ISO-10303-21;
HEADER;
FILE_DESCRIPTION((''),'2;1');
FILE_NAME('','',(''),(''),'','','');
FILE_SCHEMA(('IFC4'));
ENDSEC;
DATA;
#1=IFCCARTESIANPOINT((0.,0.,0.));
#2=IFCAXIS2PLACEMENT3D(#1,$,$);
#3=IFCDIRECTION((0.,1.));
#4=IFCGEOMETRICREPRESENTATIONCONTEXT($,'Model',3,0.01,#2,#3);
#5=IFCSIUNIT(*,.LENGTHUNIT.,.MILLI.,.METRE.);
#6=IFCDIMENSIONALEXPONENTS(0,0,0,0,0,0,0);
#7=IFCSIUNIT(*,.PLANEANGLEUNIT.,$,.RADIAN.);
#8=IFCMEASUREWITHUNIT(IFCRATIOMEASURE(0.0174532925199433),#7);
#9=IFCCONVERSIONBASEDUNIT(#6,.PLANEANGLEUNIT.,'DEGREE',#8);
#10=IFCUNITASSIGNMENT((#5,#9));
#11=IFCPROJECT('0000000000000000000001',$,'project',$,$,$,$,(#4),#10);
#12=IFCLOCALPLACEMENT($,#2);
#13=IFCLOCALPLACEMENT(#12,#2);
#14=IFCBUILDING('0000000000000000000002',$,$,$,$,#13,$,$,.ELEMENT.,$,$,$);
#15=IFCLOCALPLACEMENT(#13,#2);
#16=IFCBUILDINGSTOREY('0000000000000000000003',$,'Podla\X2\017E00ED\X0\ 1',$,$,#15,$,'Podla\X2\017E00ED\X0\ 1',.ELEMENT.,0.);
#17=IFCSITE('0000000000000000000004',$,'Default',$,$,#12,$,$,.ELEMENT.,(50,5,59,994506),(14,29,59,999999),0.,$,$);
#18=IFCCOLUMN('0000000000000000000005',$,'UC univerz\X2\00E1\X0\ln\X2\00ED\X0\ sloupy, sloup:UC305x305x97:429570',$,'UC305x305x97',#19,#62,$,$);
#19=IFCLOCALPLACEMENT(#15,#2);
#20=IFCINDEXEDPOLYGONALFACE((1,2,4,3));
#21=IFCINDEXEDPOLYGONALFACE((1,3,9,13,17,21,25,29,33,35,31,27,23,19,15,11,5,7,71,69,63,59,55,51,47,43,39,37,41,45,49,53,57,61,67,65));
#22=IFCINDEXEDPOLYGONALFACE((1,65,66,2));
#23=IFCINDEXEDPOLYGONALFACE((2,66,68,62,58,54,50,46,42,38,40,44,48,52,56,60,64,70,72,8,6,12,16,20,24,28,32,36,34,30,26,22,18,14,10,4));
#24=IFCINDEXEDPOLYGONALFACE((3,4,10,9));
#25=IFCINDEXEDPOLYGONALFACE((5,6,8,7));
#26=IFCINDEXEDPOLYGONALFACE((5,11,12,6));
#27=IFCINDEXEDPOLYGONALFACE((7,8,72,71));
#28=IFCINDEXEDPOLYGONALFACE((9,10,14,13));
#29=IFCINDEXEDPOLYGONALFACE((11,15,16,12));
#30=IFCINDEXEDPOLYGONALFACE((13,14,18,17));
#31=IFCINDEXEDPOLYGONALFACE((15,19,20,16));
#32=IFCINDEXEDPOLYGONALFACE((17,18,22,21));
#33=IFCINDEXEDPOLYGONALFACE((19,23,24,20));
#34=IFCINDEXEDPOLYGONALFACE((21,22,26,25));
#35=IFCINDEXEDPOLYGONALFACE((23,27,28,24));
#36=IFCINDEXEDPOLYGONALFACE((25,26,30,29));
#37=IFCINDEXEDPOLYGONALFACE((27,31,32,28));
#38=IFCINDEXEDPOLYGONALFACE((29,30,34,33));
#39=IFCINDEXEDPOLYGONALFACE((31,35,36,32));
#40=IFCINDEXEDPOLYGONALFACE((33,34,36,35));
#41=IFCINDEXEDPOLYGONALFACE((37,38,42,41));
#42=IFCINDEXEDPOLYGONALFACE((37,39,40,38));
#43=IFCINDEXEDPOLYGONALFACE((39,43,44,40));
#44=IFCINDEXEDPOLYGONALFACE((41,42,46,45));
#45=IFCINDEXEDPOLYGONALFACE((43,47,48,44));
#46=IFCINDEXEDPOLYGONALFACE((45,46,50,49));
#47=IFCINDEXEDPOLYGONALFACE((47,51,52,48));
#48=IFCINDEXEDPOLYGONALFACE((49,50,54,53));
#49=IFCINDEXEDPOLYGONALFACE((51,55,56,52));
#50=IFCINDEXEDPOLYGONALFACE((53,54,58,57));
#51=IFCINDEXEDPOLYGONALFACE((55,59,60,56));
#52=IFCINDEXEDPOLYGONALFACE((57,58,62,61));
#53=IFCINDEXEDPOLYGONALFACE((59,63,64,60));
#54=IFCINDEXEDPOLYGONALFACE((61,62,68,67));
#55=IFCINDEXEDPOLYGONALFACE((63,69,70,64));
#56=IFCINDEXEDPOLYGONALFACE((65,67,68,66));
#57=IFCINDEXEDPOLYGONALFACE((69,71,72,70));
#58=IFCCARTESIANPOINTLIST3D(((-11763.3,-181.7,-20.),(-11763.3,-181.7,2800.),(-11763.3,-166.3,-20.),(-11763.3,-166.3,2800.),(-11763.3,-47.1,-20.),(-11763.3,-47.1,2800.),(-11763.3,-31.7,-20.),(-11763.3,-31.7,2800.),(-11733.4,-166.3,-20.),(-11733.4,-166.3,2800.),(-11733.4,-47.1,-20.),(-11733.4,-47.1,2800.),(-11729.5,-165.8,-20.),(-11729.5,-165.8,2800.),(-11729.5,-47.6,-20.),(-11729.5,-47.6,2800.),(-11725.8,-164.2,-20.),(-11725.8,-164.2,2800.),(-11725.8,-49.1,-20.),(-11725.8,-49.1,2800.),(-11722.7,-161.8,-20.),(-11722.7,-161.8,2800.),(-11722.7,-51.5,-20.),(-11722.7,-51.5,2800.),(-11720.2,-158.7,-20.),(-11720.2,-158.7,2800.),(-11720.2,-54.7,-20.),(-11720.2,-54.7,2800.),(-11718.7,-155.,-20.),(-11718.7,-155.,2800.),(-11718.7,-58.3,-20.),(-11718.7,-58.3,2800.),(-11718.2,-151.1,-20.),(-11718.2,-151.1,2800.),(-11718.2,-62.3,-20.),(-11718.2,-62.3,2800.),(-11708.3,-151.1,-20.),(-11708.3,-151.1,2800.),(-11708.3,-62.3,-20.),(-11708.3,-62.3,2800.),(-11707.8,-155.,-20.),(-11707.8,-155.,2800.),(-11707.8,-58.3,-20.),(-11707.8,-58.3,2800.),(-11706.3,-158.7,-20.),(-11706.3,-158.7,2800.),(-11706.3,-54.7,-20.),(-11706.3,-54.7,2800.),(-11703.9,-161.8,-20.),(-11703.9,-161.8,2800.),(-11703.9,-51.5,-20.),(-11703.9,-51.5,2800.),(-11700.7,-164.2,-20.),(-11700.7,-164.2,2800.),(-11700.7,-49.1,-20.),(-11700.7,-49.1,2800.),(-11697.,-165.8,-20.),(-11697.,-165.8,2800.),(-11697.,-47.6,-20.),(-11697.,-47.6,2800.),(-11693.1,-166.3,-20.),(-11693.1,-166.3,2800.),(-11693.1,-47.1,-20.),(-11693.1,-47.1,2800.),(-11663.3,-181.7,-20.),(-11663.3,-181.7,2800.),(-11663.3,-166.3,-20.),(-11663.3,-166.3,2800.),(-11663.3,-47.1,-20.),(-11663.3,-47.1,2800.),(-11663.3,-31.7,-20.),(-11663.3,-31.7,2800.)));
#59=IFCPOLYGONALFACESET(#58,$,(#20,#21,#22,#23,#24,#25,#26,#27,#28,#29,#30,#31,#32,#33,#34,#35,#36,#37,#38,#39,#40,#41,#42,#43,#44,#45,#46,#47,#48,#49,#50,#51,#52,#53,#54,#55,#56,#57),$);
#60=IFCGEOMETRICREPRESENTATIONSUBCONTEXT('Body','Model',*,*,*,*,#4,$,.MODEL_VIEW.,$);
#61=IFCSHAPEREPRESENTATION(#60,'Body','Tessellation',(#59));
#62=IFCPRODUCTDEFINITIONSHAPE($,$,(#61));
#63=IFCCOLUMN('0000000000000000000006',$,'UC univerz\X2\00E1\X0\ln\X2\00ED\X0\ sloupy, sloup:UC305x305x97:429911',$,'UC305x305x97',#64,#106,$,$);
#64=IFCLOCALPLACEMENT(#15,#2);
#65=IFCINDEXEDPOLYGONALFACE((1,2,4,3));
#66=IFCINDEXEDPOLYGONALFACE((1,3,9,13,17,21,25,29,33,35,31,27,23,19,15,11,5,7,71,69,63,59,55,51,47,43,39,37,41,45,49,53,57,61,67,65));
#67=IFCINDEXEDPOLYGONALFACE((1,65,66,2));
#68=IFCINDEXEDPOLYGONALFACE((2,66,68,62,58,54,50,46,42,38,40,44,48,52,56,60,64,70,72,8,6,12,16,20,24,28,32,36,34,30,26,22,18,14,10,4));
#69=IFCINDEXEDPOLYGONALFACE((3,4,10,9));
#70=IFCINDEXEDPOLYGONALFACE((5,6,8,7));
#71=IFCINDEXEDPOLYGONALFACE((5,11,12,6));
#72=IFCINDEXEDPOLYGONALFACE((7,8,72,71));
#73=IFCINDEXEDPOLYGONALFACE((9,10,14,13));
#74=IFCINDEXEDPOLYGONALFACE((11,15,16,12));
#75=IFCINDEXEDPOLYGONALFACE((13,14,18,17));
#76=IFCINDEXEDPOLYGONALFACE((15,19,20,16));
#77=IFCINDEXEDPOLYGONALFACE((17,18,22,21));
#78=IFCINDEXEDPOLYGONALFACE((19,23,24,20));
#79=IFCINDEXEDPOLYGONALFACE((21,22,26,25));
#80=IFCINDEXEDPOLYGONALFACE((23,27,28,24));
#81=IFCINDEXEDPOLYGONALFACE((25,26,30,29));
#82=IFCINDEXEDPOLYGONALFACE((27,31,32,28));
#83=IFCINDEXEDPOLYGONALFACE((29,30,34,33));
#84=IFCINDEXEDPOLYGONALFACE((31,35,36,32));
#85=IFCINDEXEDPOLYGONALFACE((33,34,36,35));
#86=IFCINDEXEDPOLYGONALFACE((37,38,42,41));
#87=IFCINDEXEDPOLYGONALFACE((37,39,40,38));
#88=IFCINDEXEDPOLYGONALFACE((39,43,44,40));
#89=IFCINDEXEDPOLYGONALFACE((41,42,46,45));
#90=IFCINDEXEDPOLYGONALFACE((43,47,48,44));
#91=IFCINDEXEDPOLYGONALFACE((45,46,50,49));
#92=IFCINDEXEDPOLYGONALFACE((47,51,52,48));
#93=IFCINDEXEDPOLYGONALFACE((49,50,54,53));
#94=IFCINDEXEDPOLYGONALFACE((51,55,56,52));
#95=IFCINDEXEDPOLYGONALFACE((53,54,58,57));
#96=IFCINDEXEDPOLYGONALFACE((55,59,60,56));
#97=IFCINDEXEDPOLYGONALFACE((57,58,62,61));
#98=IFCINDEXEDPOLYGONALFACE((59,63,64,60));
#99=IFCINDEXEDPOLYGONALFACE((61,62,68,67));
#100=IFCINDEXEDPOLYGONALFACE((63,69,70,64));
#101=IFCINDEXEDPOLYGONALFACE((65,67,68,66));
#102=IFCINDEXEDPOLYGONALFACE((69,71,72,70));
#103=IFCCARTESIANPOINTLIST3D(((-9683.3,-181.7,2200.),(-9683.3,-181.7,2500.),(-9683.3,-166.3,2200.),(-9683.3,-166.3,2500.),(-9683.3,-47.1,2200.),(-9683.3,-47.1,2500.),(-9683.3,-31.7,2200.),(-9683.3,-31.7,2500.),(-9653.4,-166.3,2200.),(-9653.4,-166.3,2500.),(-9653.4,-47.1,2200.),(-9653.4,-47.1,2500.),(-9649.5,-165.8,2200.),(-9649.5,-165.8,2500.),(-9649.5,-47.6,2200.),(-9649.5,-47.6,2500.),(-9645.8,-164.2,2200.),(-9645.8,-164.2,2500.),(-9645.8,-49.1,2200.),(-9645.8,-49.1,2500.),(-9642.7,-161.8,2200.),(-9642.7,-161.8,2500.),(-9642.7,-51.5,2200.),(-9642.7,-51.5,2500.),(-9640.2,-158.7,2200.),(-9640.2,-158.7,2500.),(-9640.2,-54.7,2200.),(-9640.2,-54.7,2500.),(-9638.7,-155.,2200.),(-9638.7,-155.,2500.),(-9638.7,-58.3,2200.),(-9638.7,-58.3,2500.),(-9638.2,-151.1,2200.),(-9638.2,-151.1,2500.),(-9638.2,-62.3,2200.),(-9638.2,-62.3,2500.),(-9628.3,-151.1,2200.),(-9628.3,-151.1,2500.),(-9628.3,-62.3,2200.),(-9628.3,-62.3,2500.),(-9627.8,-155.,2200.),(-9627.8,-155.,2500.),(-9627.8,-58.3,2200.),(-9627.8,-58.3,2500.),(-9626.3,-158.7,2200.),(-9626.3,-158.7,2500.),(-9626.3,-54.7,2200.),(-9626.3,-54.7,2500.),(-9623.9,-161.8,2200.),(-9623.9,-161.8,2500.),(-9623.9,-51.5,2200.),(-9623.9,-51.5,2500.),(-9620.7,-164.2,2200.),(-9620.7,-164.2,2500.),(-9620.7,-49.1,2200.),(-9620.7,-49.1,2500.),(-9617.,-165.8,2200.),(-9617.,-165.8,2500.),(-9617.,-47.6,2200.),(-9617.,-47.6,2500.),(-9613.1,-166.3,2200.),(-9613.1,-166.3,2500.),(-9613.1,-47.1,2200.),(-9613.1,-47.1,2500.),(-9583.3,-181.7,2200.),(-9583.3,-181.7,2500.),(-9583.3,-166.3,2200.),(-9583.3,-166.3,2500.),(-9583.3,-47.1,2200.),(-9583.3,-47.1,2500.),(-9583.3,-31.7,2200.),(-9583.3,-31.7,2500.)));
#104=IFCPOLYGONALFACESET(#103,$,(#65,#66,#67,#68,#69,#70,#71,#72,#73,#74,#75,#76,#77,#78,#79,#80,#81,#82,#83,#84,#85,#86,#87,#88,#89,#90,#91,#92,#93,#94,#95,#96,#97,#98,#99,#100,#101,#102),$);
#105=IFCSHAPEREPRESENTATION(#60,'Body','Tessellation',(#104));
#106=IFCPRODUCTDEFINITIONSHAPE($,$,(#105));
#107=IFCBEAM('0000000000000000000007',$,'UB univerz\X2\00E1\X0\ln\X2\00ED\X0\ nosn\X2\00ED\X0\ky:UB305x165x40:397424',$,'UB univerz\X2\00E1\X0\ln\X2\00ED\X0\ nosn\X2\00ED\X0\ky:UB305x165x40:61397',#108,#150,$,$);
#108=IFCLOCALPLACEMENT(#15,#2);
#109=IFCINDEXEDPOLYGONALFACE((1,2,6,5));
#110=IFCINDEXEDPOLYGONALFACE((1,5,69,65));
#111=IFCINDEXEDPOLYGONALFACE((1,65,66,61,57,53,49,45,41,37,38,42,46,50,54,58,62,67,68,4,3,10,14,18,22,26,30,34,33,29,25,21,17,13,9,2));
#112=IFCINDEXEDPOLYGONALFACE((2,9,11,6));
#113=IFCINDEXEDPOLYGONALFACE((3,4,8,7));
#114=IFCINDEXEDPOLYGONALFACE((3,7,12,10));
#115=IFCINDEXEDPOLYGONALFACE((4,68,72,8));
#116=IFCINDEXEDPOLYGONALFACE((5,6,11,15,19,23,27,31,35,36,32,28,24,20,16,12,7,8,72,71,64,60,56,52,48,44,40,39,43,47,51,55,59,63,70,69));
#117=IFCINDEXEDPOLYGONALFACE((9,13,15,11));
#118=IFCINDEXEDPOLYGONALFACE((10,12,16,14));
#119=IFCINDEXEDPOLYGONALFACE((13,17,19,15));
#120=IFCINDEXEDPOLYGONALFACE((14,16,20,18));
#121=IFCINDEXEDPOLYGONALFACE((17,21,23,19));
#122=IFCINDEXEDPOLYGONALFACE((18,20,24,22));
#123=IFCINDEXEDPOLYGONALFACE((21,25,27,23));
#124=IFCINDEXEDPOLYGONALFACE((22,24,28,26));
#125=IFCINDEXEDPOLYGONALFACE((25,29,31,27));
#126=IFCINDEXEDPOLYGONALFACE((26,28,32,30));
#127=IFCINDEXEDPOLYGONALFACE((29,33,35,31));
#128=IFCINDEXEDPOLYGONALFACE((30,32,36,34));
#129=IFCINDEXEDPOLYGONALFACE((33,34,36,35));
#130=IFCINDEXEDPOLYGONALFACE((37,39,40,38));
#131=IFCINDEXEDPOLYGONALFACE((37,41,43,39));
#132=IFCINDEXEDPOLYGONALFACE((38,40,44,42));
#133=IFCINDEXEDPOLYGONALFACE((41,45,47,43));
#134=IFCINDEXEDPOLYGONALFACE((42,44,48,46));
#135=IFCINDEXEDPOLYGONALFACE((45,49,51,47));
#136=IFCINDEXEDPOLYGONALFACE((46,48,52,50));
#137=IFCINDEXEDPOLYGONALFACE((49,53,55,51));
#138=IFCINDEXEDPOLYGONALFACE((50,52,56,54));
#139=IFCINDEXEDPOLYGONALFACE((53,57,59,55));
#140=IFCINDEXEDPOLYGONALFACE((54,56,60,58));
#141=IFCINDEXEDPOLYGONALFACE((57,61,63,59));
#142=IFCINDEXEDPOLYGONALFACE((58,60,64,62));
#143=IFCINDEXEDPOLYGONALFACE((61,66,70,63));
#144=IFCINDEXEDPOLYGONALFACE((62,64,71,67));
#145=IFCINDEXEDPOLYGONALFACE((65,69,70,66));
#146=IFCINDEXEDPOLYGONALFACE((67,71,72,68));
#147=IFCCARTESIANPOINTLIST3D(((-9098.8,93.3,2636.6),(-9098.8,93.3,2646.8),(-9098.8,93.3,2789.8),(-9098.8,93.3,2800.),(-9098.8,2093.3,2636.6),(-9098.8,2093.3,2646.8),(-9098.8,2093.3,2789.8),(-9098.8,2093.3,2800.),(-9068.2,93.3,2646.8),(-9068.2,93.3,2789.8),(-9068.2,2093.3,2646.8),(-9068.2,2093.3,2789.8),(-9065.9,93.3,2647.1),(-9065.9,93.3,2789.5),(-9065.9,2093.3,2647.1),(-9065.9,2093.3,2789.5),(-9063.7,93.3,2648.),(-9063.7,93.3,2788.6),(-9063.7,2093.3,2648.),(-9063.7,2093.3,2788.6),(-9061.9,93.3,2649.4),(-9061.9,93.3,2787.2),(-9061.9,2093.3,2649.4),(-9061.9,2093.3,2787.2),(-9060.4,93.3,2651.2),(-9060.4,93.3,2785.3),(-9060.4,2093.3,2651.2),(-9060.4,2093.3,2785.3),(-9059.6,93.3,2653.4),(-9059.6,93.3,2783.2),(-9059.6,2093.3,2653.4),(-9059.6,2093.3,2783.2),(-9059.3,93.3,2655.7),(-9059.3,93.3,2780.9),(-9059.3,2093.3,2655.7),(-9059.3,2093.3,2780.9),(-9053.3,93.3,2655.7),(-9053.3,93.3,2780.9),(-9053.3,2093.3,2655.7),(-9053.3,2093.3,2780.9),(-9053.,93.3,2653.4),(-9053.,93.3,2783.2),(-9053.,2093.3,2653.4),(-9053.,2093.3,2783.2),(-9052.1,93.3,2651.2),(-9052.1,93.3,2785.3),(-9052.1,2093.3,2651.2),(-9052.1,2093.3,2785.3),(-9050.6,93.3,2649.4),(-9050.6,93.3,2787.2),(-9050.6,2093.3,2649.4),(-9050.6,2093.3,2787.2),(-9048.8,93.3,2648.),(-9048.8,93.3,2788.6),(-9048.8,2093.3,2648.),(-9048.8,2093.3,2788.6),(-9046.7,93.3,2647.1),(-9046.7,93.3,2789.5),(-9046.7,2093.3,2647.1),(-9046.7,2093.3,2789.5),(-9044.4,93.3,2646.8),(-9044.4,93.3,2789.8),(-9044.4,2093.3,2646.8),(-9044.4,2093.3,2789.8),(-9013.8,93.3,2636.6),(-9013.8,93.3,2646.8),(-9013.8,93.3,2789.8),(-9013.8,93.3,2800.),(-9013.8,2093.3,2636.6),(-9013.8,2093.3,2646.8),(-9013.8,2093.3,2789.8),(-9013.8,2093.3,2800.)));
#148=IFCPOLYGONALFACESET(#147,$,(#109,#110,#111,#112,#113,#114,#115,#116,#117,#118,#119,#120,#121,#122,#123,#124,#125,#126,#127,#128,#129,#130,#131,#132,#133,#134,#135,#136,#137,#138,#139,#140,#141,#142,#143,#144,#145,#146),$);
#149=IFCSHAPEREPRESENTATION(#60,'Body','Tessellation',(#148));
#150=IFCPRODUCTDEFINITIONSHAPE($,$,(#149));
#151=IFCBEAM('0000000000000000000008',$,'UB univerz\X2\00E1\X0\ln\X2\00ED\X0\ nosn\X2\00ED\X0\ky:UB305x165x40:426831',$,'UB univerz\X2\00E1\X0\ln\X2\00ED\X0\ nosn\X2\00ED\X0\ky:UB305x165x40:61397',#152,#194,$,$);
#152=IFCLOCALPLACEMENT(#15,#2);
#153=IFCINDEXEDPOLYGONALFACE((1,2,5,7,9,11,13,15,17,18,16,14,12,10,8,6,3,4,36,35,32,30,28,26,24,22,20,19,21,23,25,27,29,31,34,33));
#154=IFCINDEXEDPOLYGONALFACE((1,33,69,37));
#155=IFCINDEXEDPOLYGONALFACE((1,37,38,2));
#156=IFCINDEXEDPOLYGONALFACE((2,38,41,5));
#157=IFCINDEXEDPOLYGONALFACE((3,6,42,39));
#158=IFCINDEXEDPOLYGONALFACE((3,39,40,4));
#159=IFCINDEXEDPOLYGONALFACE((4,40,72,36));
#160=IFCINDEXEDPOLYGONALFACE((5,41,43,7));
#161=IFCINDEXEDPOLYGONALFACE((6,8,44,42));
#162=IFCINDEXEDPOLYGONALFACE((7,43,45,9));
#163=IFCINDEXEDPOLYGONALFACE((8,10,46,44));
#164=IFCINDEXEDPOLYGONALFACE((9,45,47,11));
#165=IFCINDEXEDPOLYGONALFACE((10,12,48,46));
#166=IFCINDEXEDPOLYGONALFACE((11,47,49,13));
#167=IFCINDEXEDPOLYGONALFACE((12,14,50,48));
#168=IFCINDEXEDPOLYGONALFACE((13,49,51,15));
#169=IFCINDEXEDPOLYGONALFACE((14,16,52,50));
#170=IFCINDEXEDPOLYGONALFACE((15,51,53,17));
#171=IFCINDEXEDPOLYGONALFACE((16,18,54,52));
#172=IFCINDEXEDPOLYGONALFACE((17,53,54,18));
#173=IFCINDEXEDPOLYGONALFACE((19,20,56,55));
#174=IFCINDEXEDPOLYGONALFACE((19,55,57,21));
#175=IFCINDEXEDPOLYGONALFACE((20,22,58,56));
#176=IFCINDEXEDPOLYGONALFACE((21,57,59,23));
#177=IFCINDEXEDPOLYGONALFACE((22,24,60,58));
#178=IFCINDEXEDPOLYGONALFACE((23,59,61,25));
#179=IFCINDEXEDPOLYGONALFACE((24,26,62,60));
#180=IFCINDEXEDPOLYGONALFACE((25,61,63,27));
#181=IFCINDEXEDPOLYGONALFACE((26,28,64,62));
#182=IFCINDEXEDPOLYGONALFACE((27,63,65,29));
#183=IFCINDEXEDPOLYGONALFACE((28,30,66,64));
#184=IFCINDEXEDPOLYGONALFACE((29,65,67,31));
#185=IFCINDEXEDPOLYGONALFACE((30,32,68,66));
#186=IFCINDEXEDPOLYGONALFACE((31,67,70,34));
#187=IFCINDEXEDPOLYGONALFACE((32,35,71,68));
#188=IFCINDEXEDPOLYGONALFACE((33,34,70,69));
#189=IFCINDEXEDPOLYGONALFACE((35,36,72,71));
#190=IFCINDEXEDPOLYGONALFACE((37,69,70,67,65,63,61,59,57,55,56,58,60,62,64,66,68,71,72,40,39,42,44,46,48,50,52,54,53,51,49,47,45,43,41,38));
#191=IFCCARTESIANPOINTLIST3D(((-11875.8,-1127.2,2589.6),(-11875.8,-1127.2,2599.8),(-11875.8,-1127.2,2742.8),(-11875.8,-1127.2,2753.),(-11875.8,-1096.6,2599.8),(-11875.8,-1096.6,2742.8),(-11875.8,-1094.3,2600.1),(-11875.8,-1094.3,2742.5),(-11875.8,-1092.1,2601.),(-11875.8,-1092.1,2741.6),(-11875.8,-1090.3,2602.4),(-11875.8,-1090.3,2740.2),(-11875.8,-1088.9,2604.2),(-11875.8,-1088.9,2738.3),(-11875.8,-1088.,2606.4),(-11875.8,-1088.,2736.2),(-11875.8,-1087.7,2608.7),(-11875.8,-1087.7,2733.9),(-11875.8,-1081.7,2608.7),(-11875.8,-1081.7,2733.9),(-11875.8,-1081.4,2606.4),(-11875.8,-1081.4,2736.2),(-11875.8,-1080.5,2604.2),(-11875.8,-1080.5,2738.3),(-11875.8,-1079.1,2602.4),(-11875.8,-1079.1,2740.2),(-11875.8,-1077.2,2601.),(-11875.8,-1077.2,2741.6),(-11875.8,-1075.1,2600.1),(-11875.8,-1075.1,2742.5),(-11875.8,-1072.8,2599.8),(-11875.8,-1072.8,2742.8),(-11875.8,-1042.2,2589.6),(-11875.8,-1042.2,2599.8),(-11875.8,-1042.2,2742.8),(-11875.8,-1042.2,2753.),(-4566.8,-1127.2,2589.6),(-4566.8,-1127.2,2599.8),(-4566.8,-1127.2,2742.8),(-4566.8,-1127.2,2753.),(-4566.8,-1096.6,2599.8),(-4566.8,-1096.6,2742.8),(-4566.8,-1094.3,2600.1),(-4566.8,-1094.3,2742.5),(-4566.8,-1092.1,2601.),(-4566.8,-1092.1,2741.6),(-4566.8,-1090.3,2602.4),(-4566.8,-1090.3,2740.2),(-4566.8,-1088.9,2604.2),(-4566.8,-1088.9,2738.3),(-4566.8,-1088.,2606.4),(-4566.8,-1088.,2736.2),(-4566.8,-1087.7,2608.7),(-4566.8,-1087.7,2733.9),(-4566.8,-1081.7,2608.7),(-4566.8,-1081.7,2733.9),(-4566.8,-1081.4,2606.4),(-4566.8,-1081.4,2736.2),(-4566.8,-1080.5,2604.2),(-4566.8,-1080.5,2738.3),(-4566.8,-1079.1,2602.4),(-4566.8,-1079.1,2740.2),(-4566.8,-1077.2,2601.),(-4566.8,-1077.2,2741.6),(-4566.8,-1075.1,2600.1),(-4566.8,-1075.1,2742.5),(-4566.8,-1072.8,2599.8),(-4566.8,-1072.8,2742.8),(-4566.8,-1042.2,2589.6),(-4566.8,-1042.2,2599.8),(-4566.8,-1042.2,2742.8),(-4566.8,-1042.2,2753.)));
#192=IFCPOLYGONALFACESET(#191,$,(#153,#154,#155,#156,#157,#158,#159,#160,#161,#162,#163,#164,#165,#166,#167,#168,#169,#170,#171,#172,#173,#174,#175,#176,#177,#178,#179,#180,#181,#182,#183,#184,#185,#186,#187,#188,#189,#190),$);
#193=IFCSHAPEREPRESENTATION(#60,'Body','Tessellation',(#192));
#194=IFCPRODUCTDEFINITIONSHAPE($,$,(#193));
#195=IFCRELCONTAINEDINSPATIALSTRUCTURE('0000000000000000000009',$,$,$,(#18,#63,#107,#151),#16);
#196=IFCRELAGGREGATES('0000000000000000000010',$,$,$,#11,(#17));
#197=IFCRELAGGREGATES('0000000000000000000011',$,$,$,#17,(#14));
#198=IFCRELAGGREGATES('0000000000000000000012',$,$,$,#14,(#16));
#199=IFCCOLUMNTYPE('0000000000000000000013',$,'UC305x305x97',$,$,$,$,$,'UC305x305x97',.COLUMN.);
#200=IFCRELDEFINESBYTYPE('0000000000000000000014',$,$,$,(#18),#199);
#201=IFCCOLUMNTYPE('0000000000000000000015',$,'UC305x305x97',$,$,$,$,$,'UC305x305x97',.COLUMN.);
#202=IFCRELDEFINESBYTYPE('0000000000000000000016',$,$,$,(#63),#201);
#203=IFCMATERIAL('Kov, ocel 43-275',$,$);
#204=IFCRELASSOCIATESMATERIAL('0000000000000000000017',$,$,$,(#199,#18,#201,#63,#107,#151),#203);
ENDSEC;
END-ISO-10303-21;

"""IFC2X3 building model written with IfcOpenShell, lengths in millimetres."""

from ifc_helpers import new_model, entity, si_unit, converted_unit, direction, frame, frame_2d, origin, place, context, subcontext, project, spatial, i_section, extrude, source, transform, mapped, material, type_object, type_shapes, element, save


model = new_model("IFC2X3")

# Units and contexts
model_context = context("Model", 3, precision=0.01, world=origin(), true_north=direction((0.0, 1.0)))
body_context = subcontext(model_context, "Body", "Model", "MODEL_VIEW")
ifc_project = project(units=[si_unit("LENGTHUNIT", "METRE", prefix="MILLI"), converted_unit("PLANEANGLEUNIT", "DEGREE", entity("IfcRatioMeasure", 0.0174532925199433), si_unit("PLANEANGLEUNIT", "RADIAN"), dimensions=[0, 0, 0, 0, 0, 0, 0])], contexts=[model_context])

# Site, building, storey
site_placement = place(None, origin())
site = spatial("IfcSite", under=ifc_project, at=site_placement, Name="Default", CompositionType="ELEMENT", RefLatitude=(50, 5, 59, 994506), RefLongitude=(14, 29, 59, 999999), RefElevation=0.0)
building_placement = place(site_placement, origin())
building = spatial("IfcBuilding", under=site, at=building_placement, CompositionType="ELEMENT")
storey_placement = place(building_placement, origin())
storey = spatial("IfcBuildingStorey", under=building, at=storey_placement, Name="Podlaží 1", LongName="Podlaží 1", CompositionType="ELEMENT", Elevation=0.0)

# Columns
ifc_material = material(Name="Kov, ocel 43-275")
column_type_1 = type_object("IfcColumnType", Name="UC305x305x97", ElementType="UC305x305x97", PredefinedType="COLUMN", material=ifc_material)
shared_shape_1 = source(origin(), body_context, "Body", "SweptSolid", [
    extrude(i_section(OverallWidth=100.0, OverallDepth=150.0, WebThickness=9.9, FlangeThickness=15.4, FilletRadius=15.2, at=frame_2d((0.0, 0.0), x_axis=(0.0, 1.0))), frame((0.0, 0.0, -20.0), z_axis=(0.0, 0.0, 1.0), x_axis=(0.0, -1.0, 0.0)), (0.0, 0.0, 1.0), 2820.0),
])
type_shapes(column_type_1, [shared_shape_1])
column_1_placement = place(storey_placement, frame((-11713.3, -106.7, 0.0)))
element("IfcColumn", 1, at=column_1_placement, inside=storey, type_object=column_type_1, material=ifc_material, Name="UC univerzální sloupy, sloup:UC305x305x97:429570", ObjectType="UC305x305x97", context=body_context, shape_type="MappedRepresentation", body=[
    mapped(shared_shape_1, transform((0.0, 0.0, 0.0), scale=1.0)),
])
column_type_2 = type_object("IfcColumnType", Name="UC305x305x97", ElementType="UC305x305x97", PredefinedType="COLUMN", material=ifc_material)
shared_shape_2 = source(origin(), body_context, "Body", "SweptSolid", [
    extrude(i_section(OverallWidth=100.0, OverallDepth=150.0, WebThickness=9.9, FlangeThickness=15.4, FilletRadius=15.2, at=frame_2d((0.0, 0.0), x_axis=(0.0, 1.0))), frame((0.0, 0.0, 2200.0), z_axis=(0.0, 0.0, 1.0), x_axis=(0.0, -1.0, 0.0)), (0.0, 0.0, 1.0), 300.0),
])
type_shapes(column_type_2, [shared_shape_2])
column_2_placement = place(storey_placement, frame((-9633.3, -106.7, 0.0)))
element("IfcColumn", 2, at=column_2_placement, inside=storey, type_object=column_type_2, material=ifc_material, Name="UC univerzální sloupy, sloup:UC305x305x97:429911", ObjectType="UC305x305x97", context=body_context, shape_type="MappedRepresentation", body=[
    mapped(shared_shape_2, transform((0.0, 0.0, 0.0), scale=1.0)),
])

# Beams
beam_1_placement = place(storey_placement, frame((-9056.3, 2093.3, 0.0), z_axis=(0.0, 0.0, 1.0), x_axis=(0.0, -1.0, 0.0)))
element("IfcBeam", 3, at=beam_1_placement, inside=storey, material=ifc_material, Name="UB univerzální nosníky:UB305x165x40:397424", ObjectType="UB univerzální nosníky:UB305x165x40:61397", context=body_context, shape_type="SweptSolid", body=[
    extrude(i_section(OverallWidth=85.0, OverallDepth=163.4, WebThickness=6.0, FlangeThickness=10.2, FilletRadius=8.9, at=frame_2d((0.0, 0.0), x_axis=(0.0, 1.0))), frame((0.0, 0.0, 2718.3), z_axis=(1.0, 0.0, 0.0), x_axis=(0.0, 0.0, -1.0)), (0.0, 0.0, 1.0), 2000.0),
])
beam_2_placement = place(storey_placement, frame((-4566.8, -1084.7, 0.0), z_axis=(0.0, 0.0, 1.0), x_axis=(-1.0, 0.0, 0.0)))
element("IfcBeam", 4, at=beam_2_placement, inside=storey, material=ifc_material, Name="UB univerzální nosníky:UB305x165x40:426831", ObjectType="UB univerzální nosníky:UB305x165x40:61397", context=body_context, shape_type="SweptSolid", body=[
    extrude(i_section(OverallWidth=85.0, OverallDepth=163.4, WebThickness=6.0, FlangeThickness=10.2, FilletRadius=8.9, at=frame_2d((0.0, 0.0), x_axis=(0.0, 1.0))), frame((0.0, 0.0, 2671.3), z_axis=(1.0, 0.0, 0.0), x_axis=(0.0, 0.0, -1.0)), (0.0, 0.0, 1.0), 7309.0),
])

save(model, "model.ifc")
